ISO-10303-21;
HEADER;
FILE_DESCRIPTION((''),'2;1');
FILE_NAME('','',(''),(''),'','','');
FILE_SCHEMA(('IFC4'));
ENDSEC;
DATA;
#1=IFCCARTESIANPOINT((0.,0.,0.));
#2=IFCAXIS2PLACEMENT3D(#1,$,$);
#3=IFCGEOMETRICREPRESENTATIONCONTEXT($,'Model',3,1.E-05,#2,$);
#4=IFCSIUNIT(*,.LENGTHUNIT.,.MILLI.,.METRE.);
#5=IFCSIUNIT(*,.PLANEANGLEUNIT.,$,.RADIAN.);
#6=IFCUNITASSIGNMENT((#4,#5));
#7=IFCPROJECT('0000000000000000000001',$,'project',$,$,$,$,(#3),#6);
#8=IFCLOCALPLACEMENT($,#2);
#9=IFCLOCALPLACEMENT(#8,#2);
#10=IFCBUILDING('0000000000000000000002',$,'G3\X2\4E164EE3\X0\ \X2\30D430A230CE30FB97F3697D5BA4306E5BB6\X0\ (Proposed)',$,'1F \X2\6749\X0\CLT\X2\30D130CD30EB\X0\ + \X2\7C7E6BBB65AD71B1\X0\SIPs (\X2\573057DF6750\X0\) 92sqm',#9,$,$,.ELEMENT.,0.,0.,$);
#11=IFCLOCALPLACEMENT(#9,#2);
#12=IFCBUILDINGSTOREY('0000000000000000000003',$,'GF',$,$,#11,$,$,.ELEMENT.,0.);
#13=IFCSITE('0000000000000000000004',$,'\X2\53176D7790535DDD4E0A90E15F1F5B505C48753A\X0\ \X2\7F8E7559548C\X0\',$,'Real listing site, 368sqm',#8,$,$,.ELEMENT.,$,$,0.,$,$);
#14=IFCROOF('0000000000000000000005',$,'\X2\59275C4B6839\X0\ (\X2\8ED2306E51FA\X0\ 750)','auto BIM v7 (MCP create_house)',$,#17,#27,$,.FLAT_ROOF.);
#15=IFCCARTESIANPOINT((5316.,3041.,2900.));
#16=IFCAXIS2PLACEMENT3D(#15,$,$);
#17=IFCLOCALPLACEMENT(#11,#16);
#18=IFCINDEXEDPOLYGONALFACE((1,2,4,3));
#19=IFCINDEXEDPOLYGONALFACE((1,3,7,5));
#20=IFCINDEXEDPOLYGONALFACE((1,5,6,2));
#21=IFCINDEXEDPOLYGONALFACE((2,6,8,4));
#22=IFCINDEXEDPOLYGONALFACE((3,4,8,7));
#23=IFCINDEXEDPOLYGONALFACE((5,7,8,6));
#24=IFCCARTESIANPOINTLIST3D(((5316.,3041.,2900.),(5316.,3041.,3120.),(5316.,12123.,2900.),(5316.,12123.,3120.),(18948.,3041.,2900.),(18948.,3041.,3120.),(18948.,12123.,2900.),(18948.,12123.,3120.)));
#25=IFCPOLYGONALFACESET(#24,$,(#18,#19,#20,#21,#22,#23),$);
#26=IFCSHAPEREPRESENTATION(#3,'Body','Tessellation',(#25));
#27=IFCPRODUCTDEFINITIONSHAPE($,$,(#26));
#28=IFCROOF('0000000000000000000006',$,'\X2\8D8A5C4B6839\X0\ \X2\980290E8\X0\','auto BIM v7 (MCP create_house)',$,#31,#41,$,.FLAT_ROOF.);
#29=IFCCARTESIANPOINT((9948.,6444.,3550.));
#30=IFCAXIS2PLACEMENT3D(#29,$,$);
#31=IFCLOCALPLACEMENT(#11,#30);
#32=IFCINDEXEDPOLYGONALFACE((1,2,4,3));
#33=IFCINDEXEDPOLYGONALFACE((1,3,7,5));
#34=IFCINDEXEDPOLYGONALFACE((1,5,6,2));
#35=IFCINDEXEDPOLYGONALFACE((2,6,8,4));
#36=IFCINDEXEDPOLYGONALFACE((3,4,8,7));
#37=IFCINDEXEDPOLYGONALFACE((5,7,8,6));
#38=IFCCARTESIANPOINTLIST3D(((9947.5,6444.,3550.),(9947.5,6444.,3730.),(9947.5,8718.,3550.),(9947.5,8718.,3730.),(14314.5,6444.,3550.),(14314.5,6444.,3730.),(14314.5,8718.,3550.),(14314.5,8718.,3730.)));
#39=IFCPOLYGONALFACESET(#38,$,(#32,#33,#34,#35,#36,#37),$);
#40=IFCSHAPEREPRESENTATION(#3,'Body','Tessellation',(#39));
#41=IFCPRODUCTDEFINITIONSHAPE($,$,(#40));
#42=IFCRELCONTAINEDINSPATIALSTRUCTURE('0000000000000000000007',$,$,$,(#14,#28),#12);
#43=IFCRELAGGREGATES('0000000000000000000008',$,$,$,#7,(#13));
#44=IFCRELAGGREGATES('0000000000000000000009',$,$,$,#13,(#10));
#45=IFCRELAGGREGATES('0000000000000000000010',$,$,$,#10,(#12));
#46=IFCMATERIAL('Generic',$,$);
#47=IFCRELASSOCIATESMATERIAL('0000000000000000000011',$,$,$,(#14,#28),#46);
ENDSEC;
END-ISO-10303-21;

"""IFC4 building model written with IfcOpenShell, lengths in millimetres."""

from ifc_helpers import new_model, si_unit, frame, frame_2d, origin, place, context, project, spatial, rectangle, extrude, material, element, save


model = new_model("IFC4")

# Units and contexts
model_context = context("Model", 3, precision=1e-05, world=origin())
ifc_project = project(units=[si_unit("LENGTHUNIT", "METRE", prefix="MILLI"), si_unit("PLANEANGLEUNIT", "RADIAN")], contexts=[model_context])

# Site, building, storey
site_placement = place(None, origin())
site = spatial("IfcSite", under=ifc_project, at=site_placement, Name="北海道川上郡弟子屈町 美留和", ObjectType="Real listing site, 368sqm", CompositionType="ELEMENT", RefElevation=0.0)
building_placement = place(site_placement, origin())
building = spatial("IfcBuilding", under=site, at=building_placement, Name="G3世代 ピアノ・音楽室の家 (Proposed)", ObjectType="1F 杉CLTパネル + 籾殻断熱SIPs (地域材) 92sqm", CompositionType="ELEMENT", ElevationOfRefHeight=0.0, ElevationOfTerrain=0.0)
storey_placement = place(building_placement, origin())
storey = spatial("IfcBuildingStorey", under=building, at=storey_placement, Name="GF", CompositionType="ELEMENT", Elevation=0.0)

# Shared definitions
ifc_material = material(Name="Generic")

# Roofs
roof_1_placement = place(storey_placement, frame((5316.0, 3041.0, 2900.0)))
element("IfcRoof", 1, at=roof_1_placement, inside=storey, material=ifc_material, Name="大屋根 (軒の出 750)", Description="auto BIM v7 (MCP create_house)", PredefinedType="FLAT_ROOF", context=model_context, shape_type="SweptSolid", body=[
    extrude(rectangle(XDim=13632.0, YDim=9082.0, at=frame_2d((6816.0, 4541.0))), frame((5316.0, 3041.0, 2900.0)), (0.0, 0.0, 1.0), 220.0),
])
roof_2_placement = place(storey_placement, frame((9948.0, 6444.0, 3550.0)))
element("IfcRoof", 2, at=roof_2_placement, inside=storey, material=ifc_material, Name="越屋根 頂部", Description="auto BIM v7 (MCP create_house)", PredefinedType="FLAT_ROOF", context=model_context, shape_type="SweptSolid", body=[
    extrude(rectangle(XDim=4367.0, YDim=2274.0, at=frame_2d((2183.0, 1137.0))), frame((9948.0, 6444.0, 3550.0)), (0.0, 0.0, 1.0), 180.0),
])

save(model, "model.ifc")
